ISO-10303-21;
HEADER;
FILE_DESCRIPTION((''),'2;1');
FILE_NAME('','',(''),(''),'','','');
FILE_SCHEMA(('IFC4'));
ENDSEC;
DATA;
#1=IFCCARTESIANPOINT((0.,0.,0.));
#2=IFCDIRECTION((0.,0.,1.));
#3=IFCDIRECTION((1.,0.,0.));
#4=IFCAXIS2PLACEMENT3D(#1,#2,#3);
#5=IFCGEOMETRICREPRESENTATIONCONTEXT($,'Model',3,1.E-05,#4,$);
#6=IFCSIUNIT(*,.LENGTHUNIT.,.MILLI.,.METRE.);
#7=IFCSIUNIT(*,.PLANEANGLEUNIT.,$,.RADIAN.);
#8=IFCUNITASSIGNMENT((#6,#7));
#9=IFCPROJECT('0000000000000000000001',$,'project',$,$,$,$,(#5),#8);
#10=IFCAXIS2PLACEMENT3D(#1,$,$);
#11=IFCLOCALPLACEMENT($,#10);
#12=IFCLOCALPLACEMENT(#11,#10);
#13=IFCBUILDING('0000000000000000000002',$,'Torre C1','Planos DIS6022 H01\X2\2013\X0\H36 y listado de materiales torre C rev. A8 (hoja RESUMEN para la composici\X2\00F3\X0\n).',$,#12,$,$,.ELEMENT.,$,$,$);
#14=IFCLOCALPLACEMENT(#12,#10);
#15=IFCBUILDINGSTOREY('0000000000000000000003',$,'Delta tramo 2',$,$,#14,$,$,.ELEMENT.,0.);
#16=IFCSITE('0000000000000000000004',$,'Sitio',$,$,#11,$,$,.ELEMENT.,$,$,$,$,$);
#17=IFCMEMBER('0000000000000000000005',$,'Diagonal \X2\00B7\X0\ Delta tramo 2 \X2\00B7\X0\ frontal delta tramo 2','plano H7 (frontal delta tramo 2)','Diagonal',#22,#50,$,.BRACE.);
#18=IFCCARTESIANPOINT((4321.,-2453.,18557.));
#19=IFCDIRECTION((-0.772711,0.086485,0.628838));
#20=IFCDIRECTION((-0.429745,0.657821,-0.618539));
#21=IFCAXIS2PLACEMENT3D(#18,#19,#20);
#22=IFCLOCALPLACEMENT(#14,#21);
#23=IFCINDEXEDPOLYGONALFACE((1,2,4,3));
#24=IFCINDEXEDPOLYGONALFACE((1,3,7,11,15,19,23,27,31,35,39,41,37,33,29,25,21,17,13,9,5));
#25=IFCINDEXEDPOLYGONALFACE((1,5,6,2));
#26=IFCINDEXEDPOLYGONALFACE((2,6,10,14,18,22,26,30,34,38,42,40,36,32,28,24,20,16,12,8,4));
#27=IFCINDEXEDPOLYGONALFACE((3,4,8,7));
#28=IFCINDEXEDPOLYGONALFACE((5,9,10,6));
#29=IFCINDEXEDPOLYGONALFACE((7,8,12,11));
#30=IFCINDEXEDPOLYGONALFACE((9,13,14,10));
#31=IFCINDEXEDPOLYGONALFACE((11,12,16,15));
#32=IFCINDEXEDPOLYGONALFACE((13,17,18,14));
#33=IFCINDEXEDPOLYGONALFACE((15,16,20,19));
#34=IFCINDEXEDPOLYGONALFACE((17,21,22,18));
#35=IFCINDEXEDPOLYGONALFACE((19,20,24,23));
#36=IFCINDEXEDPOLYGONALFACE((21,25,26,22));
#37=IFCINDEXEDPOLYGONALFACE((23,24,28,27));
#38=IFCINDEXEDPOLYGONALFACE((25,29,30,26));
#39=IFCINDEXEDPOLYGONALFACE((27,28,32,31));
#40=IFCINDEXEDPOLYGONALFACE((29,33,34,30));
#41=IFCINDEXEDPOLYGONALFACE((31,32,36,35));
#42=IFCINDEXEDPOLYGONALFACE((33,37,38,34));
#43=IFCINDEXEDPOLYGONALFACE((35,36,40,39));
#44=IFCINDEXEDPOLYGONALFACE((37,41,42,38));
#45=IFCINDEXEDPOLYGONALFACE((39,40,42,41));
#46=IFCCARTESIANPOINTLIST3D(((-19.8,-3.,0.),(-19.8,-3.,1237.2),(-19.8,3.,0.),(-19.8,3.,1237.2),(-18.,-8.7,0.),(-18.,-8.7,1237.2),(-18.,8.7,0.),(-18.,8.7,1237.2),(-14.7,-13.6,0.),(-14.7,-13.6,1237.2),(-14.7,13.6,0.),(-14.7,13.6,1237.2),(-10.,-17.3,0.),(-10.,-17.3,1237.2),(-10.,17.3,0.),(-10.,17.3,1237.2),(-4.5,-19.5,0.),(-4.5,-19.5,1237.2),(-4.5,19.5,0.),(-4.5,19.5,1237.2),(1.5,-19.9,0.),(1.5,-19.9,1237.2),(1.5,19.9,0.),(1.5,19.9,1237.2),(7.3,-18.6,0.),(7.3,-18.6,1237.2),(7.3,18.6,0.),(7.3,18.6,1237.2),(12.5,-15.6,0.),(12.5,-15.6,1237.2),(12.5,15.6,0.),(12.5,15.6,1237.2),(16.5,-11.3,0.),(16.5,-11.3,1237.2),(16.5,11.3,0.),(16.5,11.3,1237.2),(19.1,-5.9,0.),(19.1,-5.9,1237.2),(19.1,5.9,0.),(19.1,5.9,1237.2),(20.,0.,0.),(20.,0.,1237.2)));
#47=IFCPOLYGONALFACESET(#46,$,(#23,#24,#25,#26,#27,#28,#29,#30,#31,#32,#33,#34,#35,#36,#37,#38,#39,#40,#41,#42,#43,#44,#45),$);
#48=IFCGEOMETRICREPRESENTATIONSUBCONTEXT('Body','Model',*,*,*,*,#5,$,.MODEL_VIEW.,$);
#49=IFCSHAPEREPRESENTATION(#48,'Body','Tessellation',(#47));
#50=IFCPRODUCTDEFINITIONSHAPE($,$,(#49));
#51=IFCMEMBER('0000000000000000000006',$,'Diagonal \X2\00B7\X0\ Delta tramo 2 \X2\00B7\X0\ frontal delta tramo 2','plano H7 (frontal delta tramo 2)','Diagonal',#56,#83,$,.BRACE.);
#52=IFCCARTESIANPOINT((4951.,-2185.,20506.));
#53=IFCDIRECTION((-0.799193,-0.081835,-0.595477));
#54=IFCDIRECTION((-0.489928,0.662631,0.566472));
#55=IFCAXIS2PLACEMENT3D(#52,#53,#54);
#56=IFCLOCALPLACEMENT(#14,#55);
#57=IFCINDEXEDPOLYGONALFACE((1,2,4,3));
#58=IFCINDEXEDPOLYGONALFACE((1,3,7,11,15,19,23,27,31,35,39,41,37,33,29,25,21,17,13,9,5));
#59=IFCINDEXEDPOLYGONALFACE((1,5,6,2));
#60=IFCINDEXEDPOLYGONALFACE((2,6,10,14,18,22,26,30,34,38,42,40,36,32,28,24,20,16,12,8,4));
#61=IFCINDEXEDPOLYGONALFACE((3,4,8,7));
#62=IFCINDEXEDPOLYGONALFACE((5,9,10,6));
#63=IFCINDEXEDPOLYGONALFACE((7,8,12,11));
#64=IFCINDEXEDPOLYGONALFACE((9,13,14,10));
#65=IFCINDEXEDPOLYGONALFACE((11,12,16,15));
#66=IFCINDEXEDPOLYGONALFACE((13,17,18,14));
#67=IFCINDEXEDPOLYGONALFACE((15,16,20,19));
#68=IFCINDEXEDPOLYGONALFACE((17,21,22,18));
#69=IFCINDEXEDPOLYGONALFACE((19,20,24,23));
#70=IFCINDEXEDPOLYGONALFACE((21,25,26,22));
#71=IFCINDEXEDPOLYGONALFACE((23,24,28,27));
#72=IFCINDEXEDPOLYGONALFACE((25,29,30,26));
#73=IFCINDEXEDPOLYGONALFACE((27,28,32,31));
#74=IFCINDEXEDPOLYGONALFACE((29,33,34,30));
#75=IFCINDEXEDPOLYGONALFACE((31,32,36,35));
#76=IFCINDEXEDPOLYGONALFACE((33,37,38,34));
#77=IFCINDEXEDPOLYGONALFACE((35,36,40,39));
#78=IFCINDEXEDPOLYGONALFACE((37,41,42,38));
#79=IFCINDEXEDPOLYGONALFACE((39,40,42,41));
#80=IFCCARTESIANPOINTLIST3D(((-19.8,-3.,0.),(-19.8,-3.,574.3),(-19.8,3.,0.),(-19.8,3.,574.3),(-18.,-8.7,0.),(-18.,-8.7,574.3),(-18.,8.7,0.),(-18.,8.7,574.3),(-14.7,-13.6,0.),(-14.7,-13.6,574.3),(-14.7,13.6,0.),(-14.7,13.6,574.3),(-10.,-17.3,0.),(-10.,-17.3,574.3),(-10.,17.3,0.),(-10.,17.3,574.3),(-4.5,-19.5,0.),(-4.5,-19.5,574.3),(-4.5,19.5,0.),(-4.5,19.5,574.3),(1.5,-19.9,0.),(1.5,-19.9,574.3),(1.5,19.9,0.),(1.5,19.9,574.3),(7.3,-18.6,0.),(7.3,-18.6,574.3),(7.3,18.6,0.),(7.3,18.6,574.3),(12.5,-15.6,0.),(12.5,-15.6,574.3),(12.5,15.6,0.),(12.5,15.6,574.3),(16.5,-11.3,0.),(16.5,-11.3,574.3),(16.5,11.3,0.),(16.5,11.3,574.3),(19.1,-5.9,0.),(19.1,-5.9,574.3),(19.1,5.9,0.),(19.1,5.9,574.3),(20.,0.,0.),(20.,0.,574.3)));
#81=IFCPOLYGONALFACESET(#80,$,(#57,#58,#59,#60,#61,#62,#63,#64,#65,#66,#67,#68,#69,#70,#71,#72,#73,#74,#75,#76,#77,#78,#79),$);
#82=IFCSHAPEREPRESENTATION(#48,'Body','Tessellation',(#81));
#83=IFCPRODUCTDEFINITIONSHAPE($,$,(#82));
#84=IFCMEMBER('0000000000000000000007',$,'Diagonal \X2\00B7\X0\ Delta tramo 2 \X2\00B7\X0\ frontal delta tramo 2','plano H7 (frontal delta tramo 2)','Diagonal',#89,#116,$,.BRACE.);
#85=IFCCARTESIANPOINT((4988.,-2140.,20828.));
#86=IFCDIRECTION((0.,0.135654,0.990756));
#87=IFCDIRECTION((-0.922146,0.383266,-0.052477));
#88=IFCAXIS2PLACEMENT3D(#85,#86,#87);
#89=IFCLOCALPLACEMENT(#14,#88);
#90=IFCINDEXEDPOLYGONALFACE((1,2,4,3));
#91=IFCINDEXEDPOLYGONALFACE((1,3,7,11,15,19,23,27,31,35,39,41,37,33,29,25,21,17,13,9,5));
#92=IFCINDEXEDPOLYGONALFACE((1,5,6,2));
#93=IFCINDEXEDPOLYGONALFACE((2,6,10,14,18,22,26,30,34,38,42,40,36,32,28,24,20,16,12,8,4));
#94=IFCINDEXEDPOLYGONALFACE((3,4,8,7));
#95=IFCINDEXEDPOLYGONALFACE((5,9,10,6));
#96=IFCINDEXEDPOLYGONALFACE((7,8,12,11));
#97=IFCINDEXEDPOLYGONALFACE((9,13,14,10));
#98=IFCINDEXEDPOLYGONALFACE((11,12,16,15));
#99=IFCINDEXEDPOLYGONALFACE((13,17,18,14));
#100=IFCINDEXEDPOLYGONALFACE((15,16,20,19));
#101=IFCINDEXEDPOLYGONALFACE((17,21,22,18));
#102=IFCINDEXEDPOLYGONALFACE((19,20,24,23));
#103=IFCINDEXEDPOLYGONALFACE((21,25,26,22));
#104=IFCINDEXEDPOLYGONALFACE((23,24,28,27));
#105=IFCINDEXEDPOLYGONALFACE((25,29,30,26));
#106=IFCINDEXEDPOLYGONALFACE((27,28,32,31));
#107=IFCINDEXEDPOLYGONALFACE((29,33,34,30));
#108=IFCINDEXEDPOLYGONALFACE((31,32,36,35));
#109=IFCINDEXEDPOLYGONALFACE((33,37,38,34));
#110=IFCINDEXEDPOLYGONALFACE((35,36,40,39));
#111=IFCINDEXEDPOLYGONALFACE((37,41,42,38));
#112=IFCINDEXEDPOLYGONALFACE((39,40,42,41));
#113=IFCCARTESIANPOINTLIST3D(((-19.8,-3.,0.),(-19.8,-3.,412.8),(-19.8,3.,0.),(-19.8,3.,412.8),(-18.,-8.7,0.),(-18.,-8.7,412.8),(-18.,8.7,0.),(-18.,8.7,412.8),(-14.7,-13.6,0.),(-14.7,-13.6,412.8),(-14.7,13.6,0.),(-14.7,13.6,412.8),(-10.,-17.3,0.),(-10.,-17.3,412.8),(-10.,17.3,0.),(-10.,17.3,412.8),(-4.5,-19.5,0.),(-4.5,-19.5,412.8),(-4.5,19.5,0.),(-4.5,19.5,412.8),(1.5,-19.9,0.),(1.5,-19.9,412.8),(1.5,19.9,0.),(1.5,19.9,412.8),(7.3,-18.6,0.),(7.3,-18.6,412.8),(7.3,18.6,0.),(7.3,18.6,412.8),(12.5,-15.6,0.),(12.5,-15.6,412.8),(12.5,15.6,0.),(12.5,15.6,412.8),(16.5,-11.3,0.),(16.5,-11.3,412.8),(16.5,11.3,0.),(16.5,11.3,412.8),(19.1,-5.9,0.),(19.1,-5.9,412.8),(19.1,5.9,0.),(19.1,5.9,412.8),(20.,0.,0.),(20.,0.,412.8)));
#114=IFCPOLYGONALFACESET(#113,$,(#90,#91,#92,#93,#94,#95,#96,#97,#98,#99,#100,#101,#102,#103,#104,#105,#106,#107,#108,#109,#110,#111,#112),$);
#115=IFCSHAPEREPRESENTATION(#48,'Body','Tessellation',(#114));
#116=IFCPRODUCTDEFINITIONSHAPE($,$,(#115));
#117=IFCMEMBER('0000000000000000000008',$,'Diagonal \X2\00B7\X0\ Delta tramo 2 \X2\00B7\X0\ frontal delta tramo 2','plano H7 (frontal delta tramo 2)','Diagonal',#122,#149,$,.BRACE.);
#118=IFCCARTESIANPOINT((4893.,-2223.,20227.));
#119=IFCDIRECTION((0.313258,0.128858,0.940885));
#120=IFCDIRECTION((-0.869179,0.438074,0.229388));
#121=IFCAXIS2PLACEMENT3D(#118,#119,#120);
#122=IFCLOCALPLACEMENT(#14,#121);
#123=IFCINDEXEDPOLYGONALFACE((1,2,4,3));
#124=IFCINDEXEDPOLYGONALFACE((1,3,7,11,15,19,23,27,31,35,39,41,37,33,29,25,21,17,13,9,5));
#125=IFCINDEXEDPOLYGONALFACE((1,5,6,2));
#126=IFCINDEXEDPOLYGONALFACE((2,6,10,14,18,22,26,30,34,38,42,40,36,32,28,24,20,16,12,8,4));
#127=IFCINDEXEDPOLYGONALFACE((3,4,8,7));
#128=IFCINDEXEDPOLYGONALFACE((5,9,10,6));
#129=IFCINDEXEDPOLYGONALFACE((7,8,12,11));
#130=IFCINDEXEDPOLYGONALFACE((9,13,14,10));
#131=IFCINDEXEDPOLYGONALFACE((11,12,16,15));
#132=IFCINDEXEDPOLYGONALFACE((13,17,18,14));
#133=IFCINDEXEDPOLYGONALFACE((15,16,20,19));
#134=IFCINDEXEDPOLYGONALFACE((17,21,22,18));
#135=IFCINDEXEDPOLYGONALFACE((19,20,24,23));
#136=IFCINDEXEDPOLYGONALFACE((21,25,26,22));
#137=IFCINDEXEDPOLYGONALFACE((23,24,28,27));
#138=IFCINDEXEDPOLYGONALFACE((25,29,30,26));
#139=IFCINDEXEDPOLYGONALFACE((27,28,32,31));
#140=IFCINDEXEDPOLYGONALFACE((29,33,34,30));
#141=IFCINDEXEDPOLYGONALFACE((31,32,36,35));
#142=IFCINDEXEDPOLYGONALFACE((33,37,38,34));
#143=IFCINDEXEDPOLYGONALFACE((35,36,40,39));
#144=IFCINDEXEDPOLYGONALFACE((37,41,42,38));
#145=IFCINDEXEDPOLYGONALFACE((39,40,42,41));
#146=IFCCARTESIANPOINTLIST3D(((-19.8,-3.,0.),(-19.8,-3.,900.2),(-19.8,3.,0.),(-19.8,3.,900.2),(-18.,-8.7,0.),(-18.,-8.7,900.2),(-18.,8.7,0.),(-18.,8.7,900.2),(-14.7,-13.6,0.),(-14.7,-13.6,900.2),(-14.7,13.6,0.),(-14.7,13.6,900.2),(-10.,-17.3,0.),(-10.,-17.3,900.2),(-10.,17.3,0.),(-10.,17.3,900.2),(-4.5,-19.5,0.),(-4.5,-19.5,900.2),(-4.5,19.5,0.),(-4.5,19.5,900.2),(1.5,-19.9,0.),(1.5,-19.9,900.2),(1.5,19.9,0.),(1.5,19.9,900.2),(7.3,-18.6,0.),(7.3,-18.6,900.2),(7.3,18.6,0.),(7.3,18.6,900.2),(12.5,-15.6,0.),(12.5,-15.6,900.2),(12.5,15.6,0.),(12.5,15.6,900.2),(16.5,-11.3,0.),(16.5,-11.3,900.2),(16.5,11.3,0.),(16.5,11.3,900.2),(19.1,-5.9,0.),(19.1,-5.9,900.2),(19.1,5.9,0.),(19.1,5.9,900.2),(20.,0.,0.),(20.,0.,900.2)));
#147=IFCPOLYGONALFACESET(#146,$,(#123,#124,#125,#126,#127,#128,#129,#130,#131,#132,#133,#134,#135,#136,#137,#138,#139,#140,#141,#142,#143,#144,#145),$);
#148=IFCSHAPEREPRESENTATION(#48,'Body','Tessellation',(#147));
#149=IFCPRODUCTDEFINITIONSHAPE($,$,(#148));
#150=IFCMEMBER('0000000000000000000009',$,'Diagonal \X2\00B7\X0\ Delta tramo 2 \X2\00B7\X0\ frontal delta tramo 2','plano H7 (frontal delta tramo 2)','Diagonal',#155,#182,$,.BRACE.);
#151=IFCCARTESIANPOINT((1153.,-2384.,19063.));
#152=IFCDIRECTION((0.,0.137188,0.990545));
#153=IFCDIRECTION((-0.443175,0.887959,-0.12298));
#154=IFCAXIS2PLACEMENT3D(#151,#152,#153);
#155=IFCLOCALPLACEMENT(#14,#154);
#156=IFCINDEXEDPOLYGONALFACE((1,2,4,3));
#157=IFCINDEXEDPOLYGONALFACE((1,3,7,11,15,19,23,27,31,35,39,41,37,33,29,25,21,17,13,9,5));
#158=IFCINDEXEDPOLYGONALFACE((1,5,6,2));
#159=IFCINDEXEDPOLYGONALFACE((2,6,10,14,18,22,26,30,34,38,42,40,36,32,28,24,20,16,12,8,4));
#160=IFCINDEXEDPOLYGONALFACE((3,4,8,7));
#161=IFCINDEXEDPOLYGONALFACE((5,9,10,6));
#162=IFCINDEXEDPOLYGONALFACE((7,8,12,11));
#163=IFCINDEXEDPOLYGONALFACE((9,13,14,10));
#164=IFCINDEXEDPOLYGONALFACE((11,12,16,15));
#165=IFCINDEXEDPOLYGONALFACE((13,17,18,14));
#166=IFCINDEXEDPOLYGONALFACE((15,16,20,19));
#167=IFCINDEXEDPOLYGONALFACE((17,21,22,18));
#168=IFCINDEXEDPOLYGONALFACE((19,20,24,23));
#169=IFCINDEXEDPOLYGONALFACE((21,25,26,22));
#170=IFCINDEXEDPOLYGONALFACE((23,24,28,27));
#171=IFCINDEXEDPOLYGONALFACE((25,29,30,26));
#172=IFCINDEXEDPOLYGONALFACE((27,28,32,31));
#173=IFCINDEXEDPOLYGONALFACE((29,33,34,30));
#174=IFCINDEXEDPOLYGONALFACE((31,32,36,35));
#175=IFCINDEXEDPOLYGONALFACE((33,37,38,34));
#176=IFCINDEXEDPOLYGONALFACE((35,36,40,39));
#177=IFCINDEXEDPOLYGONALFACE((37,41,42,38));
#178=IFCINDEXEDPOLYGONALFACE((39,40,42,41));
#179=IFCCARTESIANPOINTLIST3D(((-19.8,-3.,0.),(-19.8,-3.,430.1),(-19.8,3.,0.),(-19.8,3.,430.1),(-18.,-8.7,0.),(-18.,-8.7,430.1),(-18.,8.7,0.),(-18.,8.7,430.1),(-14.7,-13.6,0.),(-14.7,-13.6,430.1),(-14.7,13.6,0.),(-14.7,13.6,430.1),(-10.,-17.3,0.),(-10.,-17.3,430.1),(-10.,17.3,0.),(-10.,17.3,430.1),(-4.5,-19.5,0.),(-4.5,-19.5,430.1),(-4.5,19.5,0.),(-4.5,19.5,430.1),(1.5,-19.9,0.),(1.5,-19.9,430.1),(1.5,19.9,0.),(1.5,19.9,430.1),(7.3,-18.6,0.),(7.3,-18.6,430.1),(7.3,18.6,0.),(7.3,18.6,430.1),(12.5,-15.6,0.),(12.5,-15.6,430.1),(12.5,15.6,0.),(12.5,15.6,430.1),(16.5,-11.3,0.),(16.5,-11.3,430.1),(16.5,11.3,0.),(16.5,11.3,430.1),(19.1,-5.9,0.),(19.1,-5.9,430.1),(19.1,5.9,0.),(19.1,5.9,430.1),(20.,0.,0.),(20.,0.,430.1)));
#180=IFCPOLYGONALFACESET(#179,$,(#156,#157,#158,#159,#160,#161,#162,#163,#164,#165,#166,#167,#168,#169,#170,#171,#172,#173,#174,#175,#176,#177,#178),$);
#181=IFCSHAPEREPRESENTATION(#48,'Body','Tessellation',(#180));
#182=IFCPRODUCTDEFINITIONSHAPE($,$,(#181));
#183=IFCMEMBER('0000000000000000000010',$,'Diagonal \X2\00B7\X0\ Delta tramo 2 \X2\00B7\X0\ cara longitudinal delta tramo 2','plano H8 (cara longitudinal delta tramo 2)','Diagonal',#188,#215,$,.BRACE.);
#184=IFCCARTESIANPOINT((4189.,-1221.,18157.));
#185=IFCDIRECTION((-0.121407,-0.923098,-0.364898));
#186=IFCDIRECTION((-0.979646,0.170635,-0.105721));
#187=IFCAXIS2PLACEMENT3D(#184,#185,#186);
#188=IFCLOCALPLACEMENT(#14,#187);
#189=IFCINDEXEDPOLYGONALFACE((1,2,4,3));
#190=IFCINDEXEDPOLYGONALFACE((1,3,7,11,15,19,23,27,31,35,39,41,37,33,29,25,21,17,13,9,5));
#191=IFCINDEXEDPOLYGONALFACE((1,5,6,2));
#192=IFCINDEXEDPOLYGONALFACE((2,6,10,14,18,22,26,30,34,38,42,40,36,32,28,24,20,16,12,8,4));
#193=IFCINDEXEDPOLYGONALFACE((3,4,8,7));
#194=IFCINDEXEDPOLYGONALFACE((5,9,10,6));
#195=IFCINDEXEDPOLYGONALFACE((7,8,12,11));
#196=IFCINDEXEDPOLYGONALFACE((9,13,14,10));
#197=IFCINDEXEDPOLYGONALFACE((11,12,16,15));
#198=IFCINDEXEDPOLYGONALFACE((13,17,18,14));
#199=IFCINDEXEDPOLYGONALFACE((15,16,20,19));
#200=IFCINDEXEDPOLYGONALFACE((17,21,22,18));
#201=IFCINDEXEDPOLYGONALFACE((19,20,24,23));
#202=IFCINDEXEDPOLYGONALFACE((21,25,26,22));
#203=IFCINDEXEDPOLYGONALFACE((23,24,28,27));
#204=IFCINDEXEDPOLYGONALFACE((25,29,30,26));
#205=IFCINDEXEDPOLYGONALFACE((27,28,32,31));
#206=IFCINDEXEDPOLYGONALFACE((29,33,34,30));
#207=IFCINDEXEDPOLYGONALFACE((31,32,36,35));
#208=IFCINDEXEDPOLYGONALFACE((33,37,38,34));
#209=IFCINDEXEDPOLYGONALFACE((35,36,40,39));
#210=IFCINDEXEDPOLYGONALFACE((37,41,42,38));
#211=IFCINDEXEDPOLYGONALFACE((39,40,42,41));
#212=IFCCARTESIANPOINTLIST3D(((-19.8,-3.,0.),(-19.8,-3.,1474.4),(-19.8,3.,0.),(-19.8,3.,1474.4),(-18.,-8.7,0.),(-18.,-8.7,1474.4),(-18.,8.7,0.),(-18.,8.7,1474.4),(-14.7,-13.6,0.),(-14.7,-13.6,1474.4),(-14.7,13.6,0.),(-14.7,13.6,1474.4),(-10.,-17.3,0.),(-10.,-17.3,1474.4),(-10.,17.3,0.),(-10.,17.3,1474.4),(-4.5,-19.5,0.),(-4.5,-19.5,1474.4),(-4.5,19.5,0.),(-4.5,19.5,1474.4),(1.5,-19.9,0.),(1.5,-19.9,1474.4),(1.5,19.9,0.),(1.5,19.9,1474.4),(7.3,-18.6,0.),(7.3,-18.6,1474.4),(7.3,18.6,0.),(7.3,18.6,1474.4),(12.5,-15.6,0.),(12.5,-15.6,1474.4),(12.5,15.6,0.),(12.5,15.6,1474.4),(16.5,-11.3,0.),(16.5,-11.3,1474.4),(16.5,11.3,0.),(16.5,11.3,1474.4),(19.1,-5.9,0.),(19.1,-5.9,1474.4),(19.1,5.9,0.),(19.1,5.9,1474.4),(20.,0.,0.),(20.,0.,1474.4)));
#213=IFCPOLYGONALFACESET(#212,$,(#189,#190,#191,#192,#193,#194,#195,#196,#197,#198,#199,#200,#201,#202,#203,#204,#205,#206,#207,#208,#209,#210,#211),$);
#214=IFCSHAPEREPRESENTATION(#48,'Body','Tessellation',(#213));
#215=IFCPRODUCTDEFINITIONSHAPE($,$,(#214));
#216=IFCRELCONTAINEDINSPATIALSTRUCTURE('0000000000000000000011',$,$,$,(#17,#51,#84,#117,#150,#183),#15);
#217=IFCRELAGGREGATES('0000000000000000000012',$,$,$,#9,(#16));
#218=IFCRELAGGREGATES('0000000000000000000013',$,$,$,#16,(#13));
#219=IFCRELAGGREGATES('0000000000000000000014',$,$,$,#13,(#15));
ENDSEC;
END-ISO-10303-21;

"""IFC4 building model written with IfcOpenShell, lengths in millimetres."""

from ifc_helpers import new_model, si_unit, frame, origin, origin_with_axes, place, context, subcontext, project, spatial, circle, extrude, element, save


model = new_model("IFC4")

# Units and contexts
model_context = context("Model", 3, precision=1e-05, world=origin_with_axes())
body_context = subcontext(model_context, "Body", "Model", "MODEL_VIEW")
ifc_project = project(units=[si_unit("LENGTHUNIT", "METRE", prefix="MILLI"), si_unit("PLANEANGLEUNIT", "RADIAN")], contexts=[model_context])

# Site, building, storey
site_placement = place(None, origin())
site = spatial("IfcSite", under=ifc_project, at=site_placement, Name="Sitio", CompositionType="ELEMENT")
building_placement = place(site_placement, origin())
building = spatial("IfcBuilding", under=site, at=building_placement, Name="Torre C1", Description="Planos DIS6022 H01–H36 y listado de materiales torre C rev. A8 (hoja RESUMEN para la composición).", CompositionType="ELEMENT")
storey_placement = place(building_placement, origin())
storey = spatial("IfcBuildingStorey", under=building, at=storey_placement, Name="Delta tramo 2", CompositionType="ELEMENT", Elevation=0.0)

# Members
member_1_placement = place(storey_placement, frame((4321.0, -2453.0, 18557.0), z_axis=(-0.772711, 0.086485, 0.628838), x_axis=(-0.429745, 0.657821, -0.618539)))
element("IfcMember", 1, at=member_1_placement, inside=storey, Name="Diagonal · Delta tramo 2 · frontal delta tramo 2", Description="plano H7 (frontal delta tramo 2)", ObjectType="Diagonal", PredefinedType="BRACE", context=body_context, shape_type="SweptSolid", body=[
    extrude(circle(Radius=20.0), None, (0.0, 0.0, 1.0), 1237.2),
])
member_2_placement = place(storey_placement, frame((4951.0, -2185.0, 20506.0), z_axis=(-0.799193, -0.081835, -0.595477), x_axis=(-0.489928, 0.662631, 0.566472)))
element("IfcMember", 2, at=member_2_placement, inside=storey, Name="Diagonal · Delta tramo 2 · frontal delta tramo 2", Description="plano H7 (frontal delta tramo 2)", ObjectType="Diagonal", PredefinedType="BRACE", context=body_context, shape_type="SweptSolid", body=[
    extrude(circle(Radius=20.0), None, (0.0, 0.0, 1.0), 574.3),
])
member_3_placement = place(storey_placement, frame((4988.0, -2140.0, 20828.0), z_axis=(0.0, 0.135654, 0.990756), x_axis=(-0.922146, 0.383266, -0.052477)))
element("IfcMember", 3, at=member_3_placement, inside=storey, Name="Diagonal · Delta tramo 2 · frontal delta tramo 2", Description="plano H7 (frontal delta tramo 2)", ObjectType="Diagonal", PredefinedType="BRACE", context=body_context, shape_type="SweptSolid", body=[
    extrude(circle(Radius=20.0), None, (0.0, 0.0, 1.0), 412.8),
])
member_4_placement = place(storey_placement, frame((4893.0, -2223.0, 20227.0), z_axis=(0.313258, 0.128858, 0.940885), x_axis=(-0.869179, 0.438074, 0.229388)))
element("IfcMember", 4, at=member_4_placement, inside=storey, Name="Diagonal · Delta tramo 2 · frontal delta tramo 2", Description="plano H7 (frontal delta tramo 2)", ObjectType="Diagonal", PredefinedType="BRACE", context=body_context, shape_type="SweptSolid", body=[
    extrude(circle(Radius=20.0), None, (0.0, 0.0, 1.0), 900.2),
])
for number, where, z_axis, x_axis, name in (
    (5, (1153.0, -2384.0, 19063.0), (0.0, 0.137188, 0.990545), (-0.443175, 0.887959, -0.12298), "Diagonal · Delta tramo 2 · frontal delta tramo 2"),
):
    element("IfcMember", number, at=place(storey_placement, frame(where, z_axis=z_axis, x_axis=x_axis)), inside=storey, Name=name, Description="plano H7 (frontal delta tramo 2)", ObjectType="Diagonal", PredefinedType="BRACE", context=body_context, shape_type="SweptSolid", body=[
        extrude(circle(Radius=20.0), None, (0.0, 0.0, 1.0), 430.1),
    ])
member_5_placement = place(storey_placement, frame((4189.0, -1221.0, 18157.0), z_axis=(-0.121407, -0.923098, -0.364898), x_axis=(-0.979646, 0.170635, -0.105721)))
element("IfcMember", 6, at=member_5_placement, inside=storey, Name="Diagonal · Delta tramo 2 · cara longitudinal delta tramo 2", Description="plano H8 (cara longitudinal delta tramo 2)", ObjectType="Diagonal", PredefinedType="BRACE", context=body_context, shape_type="SweptSolid", body=[
    extrude(circle(Radius=20.0), None, (0.0, 0.0, 1.0), 1474.4),
])

save(model, "model.ifc")
